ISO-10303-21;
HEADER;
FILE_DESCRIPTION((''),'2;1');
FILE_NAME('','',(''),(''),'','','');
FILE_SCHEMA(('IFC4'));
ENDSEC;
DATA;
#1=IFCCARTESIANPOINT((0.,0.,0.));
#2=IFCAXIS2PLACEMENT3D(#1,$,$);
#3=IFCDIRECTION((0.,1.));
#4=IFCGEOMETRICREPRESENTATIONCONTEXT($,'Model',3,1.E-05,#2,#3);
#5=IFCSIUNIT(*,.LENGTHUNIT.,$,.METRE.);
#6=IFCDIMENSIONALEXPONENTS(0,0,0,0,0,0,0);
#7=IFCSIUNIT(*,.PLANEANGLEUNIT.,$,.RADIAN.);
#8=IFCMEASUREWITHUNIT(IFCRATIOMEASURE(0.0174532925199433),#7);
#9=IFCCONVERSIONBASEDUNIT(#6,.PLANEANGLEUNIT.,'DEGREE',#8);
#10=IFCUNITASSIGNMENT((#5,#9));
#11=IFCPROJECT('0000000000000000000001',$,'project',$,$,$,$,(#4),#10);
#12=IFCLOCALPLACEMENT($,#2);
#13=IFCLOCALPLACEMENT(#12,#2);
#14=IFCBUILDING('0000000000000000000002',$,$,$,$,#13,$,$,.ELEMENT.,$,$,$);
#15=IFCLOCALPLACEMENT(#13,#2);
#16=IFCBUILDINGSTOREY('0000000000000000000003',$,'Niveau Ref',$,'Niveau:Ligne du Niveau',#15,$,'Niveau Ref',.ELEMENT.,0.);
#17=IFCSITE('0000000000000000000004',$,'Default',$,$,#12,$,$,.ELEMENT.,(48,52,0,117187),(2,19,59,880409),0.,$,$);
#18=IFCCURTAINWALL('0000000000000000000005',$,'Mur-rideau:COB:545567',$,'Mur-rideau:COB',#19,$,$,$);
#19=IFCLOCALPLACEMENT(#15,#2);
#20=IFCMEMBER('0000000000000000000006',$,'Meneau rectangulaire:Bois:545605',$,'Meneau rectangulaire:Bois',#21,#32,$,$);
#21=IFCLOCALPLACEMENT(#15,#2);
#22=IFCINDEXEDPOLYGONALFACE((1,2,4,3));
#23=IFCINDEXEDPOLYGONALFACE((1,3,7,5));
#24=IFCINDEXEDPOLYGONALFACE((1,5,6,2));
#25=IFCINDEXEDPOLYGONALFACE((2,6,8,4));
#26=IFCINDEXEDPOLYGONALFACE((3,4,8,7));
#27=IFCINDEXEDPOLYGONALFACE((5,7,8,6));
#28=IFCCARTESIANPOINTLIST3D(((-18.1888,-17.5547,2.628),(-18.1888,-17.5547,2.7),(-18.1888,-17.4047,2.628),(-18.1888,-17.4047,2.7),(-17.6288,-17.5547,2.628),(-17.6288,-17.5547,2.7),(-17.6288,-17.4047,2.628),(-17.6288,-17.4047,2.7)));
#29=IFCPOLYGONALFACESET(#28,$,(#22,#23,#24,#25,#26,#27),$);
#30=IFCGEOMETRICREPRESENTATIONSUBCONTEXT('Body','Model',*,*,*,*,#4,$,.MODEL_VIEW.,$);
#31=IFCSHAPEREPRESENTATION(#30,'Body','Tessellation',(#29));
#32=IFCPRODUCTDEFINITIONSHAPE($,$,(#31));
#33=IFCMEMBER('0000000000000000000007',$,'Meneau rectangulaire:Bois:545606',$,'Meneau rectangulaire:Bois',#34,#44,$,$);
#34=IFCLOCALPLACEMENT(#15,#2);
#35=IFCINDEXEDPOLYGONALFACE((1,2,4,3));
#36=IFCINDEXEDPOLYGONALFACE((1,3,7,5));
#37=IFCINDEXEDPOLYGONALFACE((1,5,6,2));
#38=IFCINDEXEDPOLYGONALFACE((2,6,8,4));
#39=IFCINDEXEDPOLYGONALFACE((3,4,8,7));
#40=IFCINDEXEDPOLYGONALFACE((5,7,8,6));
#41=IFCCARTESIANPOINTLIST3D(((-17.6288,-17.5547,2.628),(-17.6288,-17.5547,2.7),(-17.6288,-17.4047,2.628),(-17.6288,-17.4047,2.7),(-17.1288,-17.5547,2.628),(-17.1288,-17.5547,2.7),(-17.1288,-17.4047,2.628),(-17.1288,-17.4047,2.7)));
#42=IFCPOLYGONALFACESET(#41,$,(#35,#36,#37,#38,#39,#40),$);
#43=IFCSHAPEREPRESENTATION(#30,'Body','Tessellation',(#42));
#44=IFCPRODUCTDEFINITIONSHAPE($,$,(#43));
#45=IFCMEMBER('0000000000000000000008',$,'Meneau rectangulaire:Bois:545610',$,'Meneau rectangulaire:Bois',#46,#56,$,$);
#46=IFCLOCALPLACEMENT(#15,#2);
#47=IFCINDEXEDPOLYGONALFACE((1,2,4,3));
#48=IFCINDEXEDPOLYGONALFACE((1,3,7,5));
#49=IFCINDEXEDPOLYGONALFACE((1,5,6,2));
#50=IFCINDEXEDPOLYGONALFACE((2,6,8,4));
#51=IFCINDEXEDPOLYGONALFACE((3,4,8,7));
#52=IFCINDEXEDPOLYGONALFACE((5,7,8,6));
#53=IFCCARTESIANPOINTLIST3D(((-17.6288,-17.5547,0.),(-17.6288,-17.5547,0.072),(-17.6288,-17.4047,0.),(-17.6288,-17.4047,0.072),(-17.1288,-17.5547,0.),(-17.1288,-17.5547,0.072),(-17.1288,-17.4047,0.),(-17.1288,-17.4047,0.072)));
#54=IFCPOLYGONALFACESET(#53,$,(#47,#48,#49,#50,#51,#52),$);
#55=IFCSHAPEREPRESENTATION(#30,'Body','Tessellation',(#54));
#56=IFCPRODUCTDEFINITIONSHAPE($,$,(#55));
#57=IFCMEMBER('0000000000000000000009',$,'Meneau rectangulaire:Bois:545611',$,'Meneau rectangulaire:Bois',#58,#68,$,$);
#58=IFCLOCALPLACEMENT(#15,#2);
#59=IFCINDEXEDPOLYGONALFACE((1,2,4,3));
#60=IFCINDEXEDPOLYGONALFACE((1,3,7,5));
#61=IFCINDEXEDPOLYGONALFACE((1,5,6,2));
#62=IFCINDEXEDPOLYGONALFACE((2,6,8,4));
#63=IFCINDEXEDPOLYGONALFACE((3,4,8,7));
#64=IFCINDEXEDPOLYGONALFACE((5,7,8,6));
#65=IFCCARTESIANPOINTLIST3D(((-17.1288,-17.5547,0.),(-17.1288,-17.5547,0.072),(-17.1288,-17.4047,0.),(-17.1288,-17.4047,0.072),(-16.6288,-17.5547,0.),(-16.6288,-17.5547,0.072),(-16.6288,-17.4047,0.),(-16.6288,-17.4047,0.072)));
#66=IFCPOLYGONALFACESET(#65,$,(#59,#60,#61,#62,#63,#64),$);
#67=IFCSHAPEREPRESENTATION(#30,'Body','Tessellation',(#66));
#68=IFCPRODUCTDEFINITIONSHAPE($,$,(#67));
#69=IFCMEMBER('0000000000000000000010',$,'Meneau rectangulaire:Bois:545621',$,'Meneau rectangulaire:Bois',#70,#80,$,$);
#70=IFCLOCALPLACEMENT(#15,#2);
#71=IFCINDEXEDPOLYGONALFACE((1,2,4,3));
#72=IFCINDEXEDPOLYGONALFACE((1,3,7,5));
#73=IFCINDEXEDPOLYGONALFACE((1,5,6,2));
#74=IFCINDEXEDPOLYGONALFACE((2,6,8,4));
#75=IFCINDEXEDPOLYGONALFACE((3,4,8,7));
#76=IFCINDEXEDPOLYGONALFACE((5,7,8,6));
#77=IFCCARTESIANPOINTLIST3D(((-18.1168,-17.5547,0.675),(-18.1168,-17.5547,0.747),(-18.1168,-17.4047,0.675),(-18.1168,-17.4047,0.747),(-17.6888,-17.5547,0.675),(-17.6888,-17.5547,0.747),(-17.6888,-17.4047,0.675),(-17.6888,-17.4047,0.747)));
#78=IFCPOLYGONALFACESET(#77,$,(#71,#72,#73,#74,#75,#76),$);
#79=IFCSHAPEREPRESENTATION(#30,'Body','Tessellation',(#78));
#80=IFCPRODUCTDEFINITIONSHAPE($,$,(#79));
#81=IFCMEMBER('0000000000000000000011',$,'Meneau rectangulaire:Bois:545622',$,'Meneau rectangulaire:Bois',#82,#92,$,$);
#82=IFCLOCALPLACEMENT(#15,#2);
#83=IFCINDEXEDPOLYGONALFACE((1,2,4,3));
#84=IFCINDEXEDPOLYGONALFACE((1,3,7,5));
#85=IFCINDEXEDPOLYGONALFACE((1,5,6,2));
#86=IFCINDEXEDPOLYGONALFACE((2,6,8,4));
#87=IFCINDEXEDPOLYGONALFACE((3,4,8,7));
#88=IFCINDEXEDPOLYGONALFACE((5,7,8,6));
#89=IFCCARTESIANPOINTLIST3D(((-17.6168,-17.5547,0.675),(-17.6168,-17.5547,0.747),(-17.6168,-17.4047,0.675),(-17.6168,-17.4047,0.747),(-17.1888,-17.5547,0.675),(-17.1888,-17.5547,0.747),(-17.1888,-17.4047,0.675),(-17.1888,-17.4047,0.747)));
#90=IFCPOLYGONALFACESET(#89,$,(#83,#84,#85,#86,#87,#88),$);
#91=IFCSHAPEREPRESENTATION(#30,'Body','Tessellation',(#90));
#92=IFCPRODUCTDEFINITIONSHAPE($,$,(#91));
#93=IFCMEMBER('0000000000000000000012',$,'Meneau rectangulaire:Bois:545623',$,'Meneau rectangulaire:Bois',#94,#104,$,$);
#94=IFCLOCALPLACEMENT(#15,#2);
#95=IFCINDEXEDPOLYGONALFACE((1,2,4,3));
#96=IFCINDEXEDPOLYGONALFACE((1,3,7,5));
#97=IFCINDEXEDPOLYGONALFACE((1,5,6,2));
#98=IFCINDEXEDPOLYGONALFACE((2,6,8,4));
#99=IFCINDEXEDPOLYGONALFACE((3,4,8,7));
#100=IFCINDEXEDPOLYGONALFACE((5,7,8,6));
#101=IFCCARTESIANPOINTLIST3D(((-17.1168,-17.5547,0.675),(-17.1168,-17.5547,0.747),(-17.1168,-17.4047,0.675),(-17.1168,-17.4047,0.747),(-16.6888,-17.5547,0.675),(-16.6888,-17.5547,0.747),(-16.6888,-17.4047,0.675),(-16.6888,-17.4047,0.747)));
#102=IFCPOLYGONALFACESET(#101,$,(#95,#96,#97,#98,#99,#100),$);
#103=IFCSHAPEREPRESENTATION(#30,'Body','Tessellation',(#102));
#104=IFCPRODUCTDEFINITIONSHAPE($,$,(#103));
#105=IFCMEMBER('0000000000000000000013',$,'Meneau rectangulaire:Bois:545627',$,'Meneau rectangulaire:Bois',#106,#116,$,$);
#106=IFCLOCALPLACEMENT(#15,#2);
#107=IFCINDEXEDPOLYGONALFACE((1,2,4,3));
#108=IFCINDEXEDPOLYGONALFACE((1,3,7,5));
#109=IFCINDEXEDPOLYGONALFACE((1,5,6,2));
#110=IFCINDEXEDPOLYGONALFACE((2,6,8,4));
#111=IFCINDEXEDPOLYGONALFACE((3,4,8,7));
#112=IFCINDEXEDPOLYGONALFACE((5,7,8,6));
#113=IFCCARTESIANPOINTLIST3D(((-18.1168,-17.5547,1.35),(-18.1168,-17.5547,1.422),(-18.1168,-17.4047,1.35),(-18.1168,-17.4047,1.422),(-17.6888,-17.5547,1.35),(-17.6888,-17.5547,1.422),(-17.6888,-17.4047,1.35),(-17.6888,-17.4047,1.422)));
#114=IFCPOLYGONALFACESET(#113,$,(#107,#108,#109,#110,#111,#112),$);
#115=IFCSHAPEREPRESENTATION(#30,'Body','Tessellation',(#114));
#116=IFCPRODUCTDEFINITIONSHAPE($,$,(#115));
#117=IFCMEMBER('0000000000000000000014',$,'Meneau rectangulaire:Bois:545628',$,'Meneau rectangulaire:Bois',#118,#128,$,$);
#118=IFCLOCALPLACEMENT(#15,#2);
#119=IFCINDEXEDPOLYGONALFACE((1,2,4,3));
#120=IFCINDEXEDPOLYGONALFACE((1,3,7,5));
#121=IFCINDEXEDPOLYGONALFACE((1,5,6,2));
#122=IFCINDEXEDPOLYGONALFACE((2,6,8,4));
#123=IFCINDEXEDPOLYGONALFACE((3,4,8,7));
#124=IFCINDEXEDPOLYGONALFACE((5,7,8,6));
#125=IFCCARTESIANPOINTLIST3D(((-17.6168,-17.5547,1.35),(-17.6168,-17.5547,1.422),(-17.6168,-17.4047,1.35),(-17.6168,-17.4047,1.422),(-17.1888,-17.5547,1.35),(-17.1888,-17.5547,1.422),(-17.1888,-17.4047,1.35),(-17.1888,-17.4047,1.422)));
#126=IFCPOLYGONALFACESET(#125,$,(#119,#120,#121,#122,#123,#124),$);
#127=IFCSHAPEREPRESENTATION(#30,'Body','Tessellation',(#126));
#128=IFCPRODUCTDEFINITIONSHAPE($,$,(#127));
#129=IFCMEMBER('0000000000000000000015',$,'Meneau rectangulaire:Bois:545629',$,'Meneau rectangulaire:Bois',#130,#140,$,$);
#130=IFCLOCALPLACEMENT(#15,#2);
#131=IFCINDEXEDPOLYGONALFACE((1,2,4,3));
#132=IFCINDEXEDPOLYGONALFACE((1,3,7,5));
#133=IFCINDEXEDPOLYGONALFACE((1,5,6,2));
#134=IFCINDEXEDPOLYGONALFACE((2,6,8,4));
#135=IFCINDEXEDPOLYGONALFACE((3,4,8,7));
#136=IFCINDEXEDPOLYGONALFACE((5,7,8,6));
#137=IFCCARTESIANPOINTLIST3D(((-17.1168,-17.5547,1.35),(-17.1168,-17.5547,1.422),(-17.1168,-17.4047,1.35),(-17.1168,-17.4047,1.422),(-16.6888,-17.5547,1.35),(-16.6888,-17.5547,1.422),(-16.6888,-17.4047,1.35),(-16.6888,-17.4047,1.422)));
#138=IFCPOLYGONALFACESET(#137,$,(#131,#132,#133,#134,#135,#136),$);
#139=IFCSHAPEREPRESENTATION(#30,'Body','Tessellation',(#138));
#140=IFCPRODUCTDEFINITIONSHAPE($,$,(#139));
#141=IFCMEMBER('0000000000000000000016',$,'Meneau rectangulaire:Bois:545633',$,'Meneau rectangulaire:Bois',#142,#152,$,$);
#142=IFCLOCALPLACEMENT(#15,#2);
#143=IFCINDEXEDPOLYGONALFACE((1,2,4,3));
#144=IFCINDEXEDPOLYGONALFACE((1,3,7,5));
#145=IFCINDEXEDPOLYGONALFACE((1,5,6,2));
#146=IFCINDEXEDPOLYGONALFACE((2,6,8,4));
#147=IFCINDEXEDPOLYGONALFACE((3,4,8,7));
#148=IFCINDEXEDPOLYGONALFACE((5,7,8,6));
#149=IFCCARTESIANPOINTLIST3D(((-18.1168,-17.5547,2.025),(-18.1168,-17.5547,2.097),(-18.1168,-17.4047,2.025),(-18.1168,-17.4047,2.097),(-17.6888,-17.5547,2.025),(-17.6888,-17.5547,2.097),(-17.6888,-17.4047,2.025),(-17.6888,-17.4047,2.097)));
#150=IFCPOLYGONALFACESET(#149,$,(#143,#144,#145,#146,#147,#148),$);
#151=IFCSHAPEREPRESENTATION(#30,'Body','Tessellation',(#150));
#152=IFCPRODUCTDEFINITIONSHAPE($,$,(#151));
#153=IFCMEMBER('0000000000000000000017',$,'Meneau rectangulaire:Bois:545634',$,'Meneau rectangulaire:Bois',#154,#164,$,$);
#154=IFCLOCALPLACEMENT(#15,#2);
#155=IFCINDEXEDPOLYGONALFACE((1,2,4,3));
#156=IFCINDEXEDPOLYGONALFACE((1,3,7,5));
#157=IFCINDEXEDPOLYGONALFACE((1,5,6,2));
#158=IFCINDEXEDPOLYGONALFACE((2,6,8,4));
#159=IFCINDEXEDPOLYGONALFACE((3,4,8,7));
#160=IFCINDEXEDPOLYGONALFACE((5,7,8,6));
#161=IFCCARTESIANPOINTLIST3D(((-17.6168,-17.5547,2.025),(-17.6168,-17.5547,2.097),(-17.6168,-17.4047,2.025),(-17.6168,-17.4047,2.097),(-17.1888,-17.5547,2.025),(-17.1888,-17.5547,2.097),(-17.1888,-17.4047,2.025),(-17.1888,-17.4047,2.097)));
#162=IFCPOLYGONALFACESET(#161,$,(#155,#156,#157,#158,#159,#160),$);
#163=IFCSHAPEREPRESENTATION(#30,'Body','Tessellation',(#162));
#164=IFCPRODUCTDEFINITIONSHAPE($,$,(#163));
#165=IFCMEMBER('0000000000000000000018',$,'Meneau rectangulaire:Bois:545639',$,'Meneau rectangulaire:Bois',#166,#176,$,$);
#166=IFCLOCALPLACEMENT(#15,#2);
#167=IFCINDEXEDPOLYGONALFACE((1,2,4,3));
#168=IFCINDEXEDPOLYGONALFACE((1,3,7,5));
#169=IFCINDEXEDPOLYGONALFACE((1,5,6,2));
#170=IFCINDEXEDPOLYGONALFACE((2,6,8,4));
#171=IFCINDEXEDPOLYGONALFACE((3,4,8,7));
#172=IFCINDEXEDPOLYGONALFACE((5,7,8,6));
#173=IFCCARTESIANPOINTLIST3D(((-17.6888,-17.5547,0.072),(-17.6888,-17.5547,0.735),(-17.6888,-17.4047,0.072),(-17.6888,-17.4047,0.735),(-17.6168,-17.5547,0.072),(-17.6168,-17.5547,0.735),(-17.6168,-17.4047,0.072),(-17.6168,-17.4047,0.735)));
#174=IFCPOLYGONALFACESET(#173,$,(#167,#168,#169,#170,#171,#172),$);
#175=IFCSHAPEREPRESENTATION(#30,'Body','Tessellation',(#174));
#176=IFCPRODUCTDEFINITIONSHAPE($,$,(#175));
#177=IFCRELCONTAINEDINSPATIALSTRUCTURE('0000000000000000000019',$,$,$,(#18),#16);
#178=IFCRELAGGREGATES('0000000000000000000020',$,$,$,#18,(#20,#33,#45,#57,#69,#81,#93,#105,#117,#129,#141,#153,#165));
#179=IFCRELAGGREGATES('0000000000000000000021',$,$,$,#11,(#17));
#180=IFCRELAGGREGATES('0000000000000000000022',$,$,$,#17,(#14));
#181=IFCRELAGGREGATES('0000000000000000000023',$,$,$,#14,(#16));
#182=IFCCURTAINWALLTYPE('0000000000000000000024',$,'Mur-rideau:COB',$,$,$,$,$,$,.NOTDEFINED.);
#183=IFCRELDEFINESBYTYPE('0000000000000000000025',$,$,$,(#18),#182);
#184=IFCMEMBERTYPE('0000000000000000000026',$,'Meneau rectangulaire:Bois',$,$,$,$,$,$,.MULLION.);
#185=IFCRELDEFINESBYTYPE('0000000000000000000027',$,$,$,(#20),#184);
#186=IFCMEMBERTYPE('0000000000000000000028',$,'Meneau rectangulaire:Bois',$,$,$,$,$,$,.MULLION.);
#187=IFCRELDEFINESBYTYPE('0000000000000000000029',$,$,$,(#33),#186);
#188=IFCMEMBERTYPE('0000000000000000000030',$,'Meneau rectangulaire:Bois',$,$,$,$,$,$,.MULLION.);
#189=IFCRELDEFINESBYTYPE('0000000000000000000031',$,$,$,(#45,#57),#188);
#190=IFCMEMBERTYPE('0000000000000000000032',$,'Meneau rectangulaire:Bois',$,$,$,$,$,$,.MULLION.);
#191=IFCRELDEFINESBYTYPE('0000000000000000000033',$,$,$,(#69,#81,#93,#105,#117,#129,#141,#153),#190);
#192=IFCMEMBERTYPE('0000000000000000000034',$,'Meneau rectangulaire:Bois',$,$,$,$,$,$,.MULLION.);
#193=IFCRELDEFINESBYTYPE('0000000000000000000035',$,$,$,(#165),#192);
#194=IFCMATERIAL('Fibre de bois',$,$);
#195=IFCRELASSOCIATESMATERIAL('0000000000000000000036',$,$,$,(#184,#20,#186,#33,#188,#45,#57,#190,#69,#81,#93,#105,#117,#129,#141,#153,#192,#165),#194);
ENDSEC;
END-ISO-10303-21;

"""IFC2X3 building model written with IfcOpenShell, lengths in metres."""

from ifc_helpers import new_model, entity, si_unit, converted_unit, direction, frame, origin, origin_2d_with_axis, place, context, subcontext, project, spatial, rectangle, extrude, source, transform, mapped, material, type_object, type_shapes, element, aggregate, save


model = new_model("IFC2X3")

# Units and contexts
model_context = context("Model", 3, precision=1e-05, world=origin(), true_north=direction((0.0, 1.0)))
body_context = subcontext(model_context, "Body", "Model", "MODEL_VIEW")
ifc_project = project(units=[si_unit("LENGTHUNIT", "METRE"), converted_unit("PLANEANGLEUNIT", "DEGREE", entity("IfcRatioMeasure", 0.0174532925199433), si_unit("PLANEANGLEUNIT", "RADIAN"), dimensions=[0, 0, 0, 0, 0, 0, 0])], contexts=[model_context])

# Site, building, storey
site_placement = place(None, origin())
site = spatial("IfcSite", under=ifc_project, at=site_placement, Name="Default", CompositionType="ELEMENT", RefLatitude=(48, 52, 0, 117187), RefLongitude=(2, 19, 59, 880409), RefElevation=0.0)
building_placement = place(site_placement, origin())
building = spatial("IfcBuilding", under=site, at=building_placement, CompositionType="ELEMENT")
storey_placement = place(building_placement, origin())
storey = spatial("IfcBuildingStorey", under=building, at=storey_placement, Name="Niveau Ref", ObjectType="Niveau:Ligne du Niveau", LongName="Niveau Ref", CompositionType="ELEMENT", Elevation=0.0)

# Curtain wall, members
curtain_wall_type_1 = type_object("IfcCurtainWallType", Name="Mur-rideau:COB", PredefinedType="NOTDEFINED")
curtain_wall_1_placement = place(storey_placement, origin())
curtain_wall_1 = element("IfcCurtainWall", 1, at=curtain_wall_1_placement, inside=storey, type_object=curtain_wall_type_1, Name="Mur-rideau:COB:545567", ObjectType="Mur-rideau:COB")
ifc_material_1 = material(Name="Fibre de bois")
member_type_1 = type_object("IfcMemberType", Name="Meneau rectangulaire:Bois", PredefinedType="MULLION", material=ifc_material_1)
shared_shape_1 = source(origin(), body_context, "Body", "SweptSolid", [
    extrude(rectangle(XDim=0.15, YDim=0.072, at=origin_2d_with_axis()), frame((-0.036, 0.0, -0.56), z_axis=(0.0, 0.0, 1.0), x_axis=(0.0, -1.0, 0.0)), (0.0, 0.0, 1.0), 0.56),
])
type_shapes(member_type_1, [shared_shape_1])
member_1_placement = place(storey_placement, frame((-17.6288, -17.4797, 2.7), z_axis=(1.0, 0.0, 0.0), x_axis=(0.0, 0.0, 1.0)))
member_1 = element("IfcMember", 2, at=member_1_placement, type_object=member_type_1, material=ifc_material_1, Name="Meneau rectangulaire:Bois:545605", ObjectType="Meneau rectangulaire:Bois", context=body_context, shape_type="MappedRepresentation", body=[
    mapped(shared_shape_1, transform((0.0, 0.0, 0.0), scale=1.0)),
])
member_type_2 = type_object("IfcMemberType", Name="Meneau rectangulaire:Bois", PredefinedType="MULLION", material=ifc_material_1)
shared_shape_2 = source(origin(), body_context, "Body", "SweptSolid", [
    extrude(rectangle(XDim=0.15, YDim=0.072, at=origin_2d_with_axis()), frame((-0.036, 0.0, -0.5), z_axis=(0.0, 0.0, 1.0), x_axis=(0.0, -1.0, 0.0)), (0.0, 0.0, 1.0), 0.5),
])
type_shapes(member_type_2, [shared_shape_2])
member_2_placement = place(storey_placement, frame((-17.1288, -17.4797, 2.7), z_axis=(1.0, 0.0, 0.0), x_axis=(0.0, 0.0, 1.0)))
member_2 = element("IfcMember", 3, at=member_2_placement, type_object=member_type_2, material=ifc_material_1, Name="Meneau rectangulaire:Bois:545606", ObjectType="Meneau rectangulaire:Bois", context=body_context, shape_type="MappedRepresentation", body=[
    mapped(shared_shape_2, transform((0.0, 0.0, 0.0), scale=1.0)),
])
member_type_3 = type_object("IfcMemberType", Name="Meneau rectangulaire:Bois", PredefinedType="MULLION", material=ifc_material_1)
shared_shape_3 = source(origin(), body_context, "Body", "SweptSolid", [
    extrude(rectangle(XDim=0.15, YDim=0.072, at=origin_2d_with_axis()), frame((-0.036, 0.0, -0.5), z_axis=(0.0, 0.0, 1.0), x_axis=(0.0, -1.0, 0.0)), (0.0, 0.0, 1.0), 0.5),
])
type_shapes(member_type_3, [shared_shape_3])
member_3_placement = place(storey_placement, frame((-17.6288, -17.4797, 0.0), z_axis=(-1.0, 0.0, 0.0), x_axis=(0.0, 0.0, -1.0)))
member_3 = element("IfcMember", 4, at=member_3_placement, type_object=member_type_3, material=ifc_material_1, Name="Meneau rectangulaire:Bois:545610", ObjectType="Meneau rectangulaire:Bois", context=body_context, shape_type="MappedRepresentation", body=[
    mapped(shared_shape_3, transform((0.0, 0.0, 0.0), scale=1.0)),
])
member_4_placement = place(storey_placement, frame((-17.1288, -17.4797, 0.0), z_axis=(-1.0, 0.0, 0.0), x_axis=(0.0, 0.0, -1.0)))
member_4 = element("IfcMember", 5, at=member_4_placement, type_object=member_type_3, material=ifc_material_1, Name="Meneau rectangulaire:Bois:545611", ObjectType="Meneau rectangulaire:Bois", context=body_context, shape_type="MappedRepresentation", body=[
    mapped(shared_shape_3, transform((0.0, 0.0, 0.0), scale=1.0)),
])
member_type_4 = type_object("IfcMemberType", Name="Meneau rectangulaire:Bois", PredefinedType="MULLION", material=ifc_material_1)
shared_shape_4 = source(origin(), body_context, "Body", "SweptSolid", [
    extrude(rectangle(XDim=0.15, YDim=0.072, at=origin_2d_with_axis()), frame((-0.024, 0.0, -0.428), z_axis=(0.0, 0.0, 1.0), x_axis=(0.0, -1.0, 0.0)), (0.0, 0.0, 1.0), 0.428),
])
type_shapes(member_type_4, [shared_shape_4])
member_5_placement = place(storey_placement, frame((-17.6888, -17.4797, 0.735), z_axis=(1.0, 0.0, 0.0), x_axis=(0.0, 0.0, 1.0)))
member_5 = element("IfcMember", 6, at=member_5_placement, type_object=member_type_4, material=ifc_material_1, Name="Meneau rectangulaire:Bois:545621", ObjectType="Meneau rectangulaire:Bois", context=body_context, shape_type="MappedRepresentation", body=[
    mapped(shared_shape_4, transform((0.0, 0.0, 0.0), scale=1.0)),
])
member_6_placement = place(storey_placement, frame((-17.1888, -17.4797, 0.735), z_axis=(1.0, 0.0, 0.0), x_axis=(0.0, 0.0, 1.0)))
member_6 = element("IfcMember", 7, at=member_6_placement, type_object=member_type_4, material=ifc_material_1, Name="Meneau rectangulaire:Bois:545622", ObjectType="Meneau rectangulaire:Bois", context=body_context, shape_type="MappedRepresentation", body=[
    mapped(shared_shape_4, transform((0.0, 0.0, 0.0), scale=1.0)),
])
member_7_placement = place(storey_placement, frame((-16.6888, -17.4797, 0.735), z_axis=(1.0, 0.0, 0.0), x_axis=(0.0, 0.0, 1.0)))
member_7 = element("IfcMember", 8, at=member_7_placement, type_object=member_type_4, material=ifc_material_1, Name="Meneau rectangulaire:Bois:545623", ObjectType="Meneau rectangulaire:Bois", context=body_context, shape_type="MappedRepresentation", body=[
    mapped(shared_shape_4, transform((0.0, 0.0, 0.0), scale=1.0)),
])
member_8_placement = place(storey_placement, frame((-17.6888, -17.4797, 1.41), z_axis=(1.0, 0.0, 0.0), x_axis=(0.0, 0.0, 1.0)))
member_8 = element("IfcMember", 9, at=member_8_placement, type_object=member_type_4, material=ifc_material_1, Name="Meneau rectangulaire:Bois:545627", ObjectType="Meneau rectangulaire:Bois", context=body_context, shape_type="MappedRepresentation", body=[
    mapped(shared_shape_4, transform((0.0, 0.0, 0.0), scale=1.0)),
])
member_9_placement = place(storey_placement, frame((-17.1888, -17.4797, 1.41), z_axis=(1.0, 0.0, 0.0), x_axis=(0.0, 0.0, 1.0)))
member_9 = element("IfcMember", 10, at=member_9_placement, type_object=member_type_4, material=ifc_material_1, Name="Meneau rectangulaire:Bois:545628", ObjectType="Meneau rectangulaire:Bois", context=body_context, shape_type="MappedRepresentation", body=[
    mapped(shared_shape_4, transform((0.0, 0.0, 0.0), scale=1.0)),
])
member_10_placement = place(storey_placement, frame((-16.6888, -17.4797, 1.41), z_axis=(1.0, 0.0, 0.0), x_axis=(0.0, 0.0, 1.0)))
member_10 = element("IfcMember", 11, at=member_10_placement, type_object=member_type_4, material=ifc_material_1, Name="Meneau rectangulaire:Bois:545629", ObjectType="Meneau rectangulaire:Bois", context=body_context, shape_type="MappedRepresentation", body=[
    mapped(shared_shape_4, transform((0.0, 0.0, 0.0), scale=1.0)),
])
member_11_placement = place(storey_placement, frame((-17.6888, -17.4797, 2.085), z_axis=(1.0, 0.0, 0.0), x_axis=(0.0, 0.0, 1.0)))
member_11 = element("IfcMember", 12, at=member_11_placement, type_object=member_type_4, material=ifc_material_1, Name="Meneau rectangulaire:Bois:545633", ObjectType="Meneau rectangulaire:Bois", context=body_context, shape_type="MappedRepresentation", body=[
    mapped(shared_shape_4, transform((0.0, 0.0, 0.0), scale=1.0)),
])
member_12_placement = place(storey_placement, frame((-17.1888, -17.4797, 2.085), z_axis=(1.0, 0.0, 0.0), x_axis=(0.0, 0.0, 1.0)))
member_12 = element("IfcMember", 13, at=member_12_placement, type_object=member_type_4, material=ifc_material_1, Name="Meneau rectangulaire:Bois:545634", ObjectType="Meneau rectangulaire:Bois", context=body_context, shape_type="MappedRepresentation", body=[
    mapped(shared_shape_4, transform((0.0, 0.0, 0.0), scale=1.0)),
])
member_type_5 = type_object("IfcMemberType", Name="Meneau rectangulaire:Bois", PredefinedType="MULLION", material=ifc_material_1)
shared_shape_5 = source(origin(), body_context, "Body", "SweptSolid", [
    extrude(rectangle(XDim=0.15, YDim=0.072, at=origin_2d_with_axis()), frame((-0.024, 0.0, -0.663), z_axis=(0.0, 0.0, 1.0), x_axis=(0.0, -1.0, 0.0)), (0.0, 0.0, 1.0), 0.663),
])
type_shapes(member_type_5, [shared_shape_5])
member_13_placement = place(storey_placement, frame((-17.6288, -17.4797, 0.072), z_axis=(0.0, 0.0, -1.0), x_axis=(1.0, 0.0, 0.0)))
member_13 = element("IfcMember", 14, at=member_13_placement, type_object=member_type_5, material=ifc_material_1, Name="Meneau rectangulaire:Bois:545639", ObjectType="Meneau rectangulaire:Bois", context=body_context, shape_type="MappedRepresentation", body=[
    mapped(shared_shape_5, transform((0.0, 0.0, 0.0), scale=1.0)),
])
aggregate(curtain_wall_1, [member_1, member_2, member_3, member_4, member_5, member_6, member_7, member_8, member_9, member_10, member_11, member_12, member_13])

save(model, "model.ifc")
